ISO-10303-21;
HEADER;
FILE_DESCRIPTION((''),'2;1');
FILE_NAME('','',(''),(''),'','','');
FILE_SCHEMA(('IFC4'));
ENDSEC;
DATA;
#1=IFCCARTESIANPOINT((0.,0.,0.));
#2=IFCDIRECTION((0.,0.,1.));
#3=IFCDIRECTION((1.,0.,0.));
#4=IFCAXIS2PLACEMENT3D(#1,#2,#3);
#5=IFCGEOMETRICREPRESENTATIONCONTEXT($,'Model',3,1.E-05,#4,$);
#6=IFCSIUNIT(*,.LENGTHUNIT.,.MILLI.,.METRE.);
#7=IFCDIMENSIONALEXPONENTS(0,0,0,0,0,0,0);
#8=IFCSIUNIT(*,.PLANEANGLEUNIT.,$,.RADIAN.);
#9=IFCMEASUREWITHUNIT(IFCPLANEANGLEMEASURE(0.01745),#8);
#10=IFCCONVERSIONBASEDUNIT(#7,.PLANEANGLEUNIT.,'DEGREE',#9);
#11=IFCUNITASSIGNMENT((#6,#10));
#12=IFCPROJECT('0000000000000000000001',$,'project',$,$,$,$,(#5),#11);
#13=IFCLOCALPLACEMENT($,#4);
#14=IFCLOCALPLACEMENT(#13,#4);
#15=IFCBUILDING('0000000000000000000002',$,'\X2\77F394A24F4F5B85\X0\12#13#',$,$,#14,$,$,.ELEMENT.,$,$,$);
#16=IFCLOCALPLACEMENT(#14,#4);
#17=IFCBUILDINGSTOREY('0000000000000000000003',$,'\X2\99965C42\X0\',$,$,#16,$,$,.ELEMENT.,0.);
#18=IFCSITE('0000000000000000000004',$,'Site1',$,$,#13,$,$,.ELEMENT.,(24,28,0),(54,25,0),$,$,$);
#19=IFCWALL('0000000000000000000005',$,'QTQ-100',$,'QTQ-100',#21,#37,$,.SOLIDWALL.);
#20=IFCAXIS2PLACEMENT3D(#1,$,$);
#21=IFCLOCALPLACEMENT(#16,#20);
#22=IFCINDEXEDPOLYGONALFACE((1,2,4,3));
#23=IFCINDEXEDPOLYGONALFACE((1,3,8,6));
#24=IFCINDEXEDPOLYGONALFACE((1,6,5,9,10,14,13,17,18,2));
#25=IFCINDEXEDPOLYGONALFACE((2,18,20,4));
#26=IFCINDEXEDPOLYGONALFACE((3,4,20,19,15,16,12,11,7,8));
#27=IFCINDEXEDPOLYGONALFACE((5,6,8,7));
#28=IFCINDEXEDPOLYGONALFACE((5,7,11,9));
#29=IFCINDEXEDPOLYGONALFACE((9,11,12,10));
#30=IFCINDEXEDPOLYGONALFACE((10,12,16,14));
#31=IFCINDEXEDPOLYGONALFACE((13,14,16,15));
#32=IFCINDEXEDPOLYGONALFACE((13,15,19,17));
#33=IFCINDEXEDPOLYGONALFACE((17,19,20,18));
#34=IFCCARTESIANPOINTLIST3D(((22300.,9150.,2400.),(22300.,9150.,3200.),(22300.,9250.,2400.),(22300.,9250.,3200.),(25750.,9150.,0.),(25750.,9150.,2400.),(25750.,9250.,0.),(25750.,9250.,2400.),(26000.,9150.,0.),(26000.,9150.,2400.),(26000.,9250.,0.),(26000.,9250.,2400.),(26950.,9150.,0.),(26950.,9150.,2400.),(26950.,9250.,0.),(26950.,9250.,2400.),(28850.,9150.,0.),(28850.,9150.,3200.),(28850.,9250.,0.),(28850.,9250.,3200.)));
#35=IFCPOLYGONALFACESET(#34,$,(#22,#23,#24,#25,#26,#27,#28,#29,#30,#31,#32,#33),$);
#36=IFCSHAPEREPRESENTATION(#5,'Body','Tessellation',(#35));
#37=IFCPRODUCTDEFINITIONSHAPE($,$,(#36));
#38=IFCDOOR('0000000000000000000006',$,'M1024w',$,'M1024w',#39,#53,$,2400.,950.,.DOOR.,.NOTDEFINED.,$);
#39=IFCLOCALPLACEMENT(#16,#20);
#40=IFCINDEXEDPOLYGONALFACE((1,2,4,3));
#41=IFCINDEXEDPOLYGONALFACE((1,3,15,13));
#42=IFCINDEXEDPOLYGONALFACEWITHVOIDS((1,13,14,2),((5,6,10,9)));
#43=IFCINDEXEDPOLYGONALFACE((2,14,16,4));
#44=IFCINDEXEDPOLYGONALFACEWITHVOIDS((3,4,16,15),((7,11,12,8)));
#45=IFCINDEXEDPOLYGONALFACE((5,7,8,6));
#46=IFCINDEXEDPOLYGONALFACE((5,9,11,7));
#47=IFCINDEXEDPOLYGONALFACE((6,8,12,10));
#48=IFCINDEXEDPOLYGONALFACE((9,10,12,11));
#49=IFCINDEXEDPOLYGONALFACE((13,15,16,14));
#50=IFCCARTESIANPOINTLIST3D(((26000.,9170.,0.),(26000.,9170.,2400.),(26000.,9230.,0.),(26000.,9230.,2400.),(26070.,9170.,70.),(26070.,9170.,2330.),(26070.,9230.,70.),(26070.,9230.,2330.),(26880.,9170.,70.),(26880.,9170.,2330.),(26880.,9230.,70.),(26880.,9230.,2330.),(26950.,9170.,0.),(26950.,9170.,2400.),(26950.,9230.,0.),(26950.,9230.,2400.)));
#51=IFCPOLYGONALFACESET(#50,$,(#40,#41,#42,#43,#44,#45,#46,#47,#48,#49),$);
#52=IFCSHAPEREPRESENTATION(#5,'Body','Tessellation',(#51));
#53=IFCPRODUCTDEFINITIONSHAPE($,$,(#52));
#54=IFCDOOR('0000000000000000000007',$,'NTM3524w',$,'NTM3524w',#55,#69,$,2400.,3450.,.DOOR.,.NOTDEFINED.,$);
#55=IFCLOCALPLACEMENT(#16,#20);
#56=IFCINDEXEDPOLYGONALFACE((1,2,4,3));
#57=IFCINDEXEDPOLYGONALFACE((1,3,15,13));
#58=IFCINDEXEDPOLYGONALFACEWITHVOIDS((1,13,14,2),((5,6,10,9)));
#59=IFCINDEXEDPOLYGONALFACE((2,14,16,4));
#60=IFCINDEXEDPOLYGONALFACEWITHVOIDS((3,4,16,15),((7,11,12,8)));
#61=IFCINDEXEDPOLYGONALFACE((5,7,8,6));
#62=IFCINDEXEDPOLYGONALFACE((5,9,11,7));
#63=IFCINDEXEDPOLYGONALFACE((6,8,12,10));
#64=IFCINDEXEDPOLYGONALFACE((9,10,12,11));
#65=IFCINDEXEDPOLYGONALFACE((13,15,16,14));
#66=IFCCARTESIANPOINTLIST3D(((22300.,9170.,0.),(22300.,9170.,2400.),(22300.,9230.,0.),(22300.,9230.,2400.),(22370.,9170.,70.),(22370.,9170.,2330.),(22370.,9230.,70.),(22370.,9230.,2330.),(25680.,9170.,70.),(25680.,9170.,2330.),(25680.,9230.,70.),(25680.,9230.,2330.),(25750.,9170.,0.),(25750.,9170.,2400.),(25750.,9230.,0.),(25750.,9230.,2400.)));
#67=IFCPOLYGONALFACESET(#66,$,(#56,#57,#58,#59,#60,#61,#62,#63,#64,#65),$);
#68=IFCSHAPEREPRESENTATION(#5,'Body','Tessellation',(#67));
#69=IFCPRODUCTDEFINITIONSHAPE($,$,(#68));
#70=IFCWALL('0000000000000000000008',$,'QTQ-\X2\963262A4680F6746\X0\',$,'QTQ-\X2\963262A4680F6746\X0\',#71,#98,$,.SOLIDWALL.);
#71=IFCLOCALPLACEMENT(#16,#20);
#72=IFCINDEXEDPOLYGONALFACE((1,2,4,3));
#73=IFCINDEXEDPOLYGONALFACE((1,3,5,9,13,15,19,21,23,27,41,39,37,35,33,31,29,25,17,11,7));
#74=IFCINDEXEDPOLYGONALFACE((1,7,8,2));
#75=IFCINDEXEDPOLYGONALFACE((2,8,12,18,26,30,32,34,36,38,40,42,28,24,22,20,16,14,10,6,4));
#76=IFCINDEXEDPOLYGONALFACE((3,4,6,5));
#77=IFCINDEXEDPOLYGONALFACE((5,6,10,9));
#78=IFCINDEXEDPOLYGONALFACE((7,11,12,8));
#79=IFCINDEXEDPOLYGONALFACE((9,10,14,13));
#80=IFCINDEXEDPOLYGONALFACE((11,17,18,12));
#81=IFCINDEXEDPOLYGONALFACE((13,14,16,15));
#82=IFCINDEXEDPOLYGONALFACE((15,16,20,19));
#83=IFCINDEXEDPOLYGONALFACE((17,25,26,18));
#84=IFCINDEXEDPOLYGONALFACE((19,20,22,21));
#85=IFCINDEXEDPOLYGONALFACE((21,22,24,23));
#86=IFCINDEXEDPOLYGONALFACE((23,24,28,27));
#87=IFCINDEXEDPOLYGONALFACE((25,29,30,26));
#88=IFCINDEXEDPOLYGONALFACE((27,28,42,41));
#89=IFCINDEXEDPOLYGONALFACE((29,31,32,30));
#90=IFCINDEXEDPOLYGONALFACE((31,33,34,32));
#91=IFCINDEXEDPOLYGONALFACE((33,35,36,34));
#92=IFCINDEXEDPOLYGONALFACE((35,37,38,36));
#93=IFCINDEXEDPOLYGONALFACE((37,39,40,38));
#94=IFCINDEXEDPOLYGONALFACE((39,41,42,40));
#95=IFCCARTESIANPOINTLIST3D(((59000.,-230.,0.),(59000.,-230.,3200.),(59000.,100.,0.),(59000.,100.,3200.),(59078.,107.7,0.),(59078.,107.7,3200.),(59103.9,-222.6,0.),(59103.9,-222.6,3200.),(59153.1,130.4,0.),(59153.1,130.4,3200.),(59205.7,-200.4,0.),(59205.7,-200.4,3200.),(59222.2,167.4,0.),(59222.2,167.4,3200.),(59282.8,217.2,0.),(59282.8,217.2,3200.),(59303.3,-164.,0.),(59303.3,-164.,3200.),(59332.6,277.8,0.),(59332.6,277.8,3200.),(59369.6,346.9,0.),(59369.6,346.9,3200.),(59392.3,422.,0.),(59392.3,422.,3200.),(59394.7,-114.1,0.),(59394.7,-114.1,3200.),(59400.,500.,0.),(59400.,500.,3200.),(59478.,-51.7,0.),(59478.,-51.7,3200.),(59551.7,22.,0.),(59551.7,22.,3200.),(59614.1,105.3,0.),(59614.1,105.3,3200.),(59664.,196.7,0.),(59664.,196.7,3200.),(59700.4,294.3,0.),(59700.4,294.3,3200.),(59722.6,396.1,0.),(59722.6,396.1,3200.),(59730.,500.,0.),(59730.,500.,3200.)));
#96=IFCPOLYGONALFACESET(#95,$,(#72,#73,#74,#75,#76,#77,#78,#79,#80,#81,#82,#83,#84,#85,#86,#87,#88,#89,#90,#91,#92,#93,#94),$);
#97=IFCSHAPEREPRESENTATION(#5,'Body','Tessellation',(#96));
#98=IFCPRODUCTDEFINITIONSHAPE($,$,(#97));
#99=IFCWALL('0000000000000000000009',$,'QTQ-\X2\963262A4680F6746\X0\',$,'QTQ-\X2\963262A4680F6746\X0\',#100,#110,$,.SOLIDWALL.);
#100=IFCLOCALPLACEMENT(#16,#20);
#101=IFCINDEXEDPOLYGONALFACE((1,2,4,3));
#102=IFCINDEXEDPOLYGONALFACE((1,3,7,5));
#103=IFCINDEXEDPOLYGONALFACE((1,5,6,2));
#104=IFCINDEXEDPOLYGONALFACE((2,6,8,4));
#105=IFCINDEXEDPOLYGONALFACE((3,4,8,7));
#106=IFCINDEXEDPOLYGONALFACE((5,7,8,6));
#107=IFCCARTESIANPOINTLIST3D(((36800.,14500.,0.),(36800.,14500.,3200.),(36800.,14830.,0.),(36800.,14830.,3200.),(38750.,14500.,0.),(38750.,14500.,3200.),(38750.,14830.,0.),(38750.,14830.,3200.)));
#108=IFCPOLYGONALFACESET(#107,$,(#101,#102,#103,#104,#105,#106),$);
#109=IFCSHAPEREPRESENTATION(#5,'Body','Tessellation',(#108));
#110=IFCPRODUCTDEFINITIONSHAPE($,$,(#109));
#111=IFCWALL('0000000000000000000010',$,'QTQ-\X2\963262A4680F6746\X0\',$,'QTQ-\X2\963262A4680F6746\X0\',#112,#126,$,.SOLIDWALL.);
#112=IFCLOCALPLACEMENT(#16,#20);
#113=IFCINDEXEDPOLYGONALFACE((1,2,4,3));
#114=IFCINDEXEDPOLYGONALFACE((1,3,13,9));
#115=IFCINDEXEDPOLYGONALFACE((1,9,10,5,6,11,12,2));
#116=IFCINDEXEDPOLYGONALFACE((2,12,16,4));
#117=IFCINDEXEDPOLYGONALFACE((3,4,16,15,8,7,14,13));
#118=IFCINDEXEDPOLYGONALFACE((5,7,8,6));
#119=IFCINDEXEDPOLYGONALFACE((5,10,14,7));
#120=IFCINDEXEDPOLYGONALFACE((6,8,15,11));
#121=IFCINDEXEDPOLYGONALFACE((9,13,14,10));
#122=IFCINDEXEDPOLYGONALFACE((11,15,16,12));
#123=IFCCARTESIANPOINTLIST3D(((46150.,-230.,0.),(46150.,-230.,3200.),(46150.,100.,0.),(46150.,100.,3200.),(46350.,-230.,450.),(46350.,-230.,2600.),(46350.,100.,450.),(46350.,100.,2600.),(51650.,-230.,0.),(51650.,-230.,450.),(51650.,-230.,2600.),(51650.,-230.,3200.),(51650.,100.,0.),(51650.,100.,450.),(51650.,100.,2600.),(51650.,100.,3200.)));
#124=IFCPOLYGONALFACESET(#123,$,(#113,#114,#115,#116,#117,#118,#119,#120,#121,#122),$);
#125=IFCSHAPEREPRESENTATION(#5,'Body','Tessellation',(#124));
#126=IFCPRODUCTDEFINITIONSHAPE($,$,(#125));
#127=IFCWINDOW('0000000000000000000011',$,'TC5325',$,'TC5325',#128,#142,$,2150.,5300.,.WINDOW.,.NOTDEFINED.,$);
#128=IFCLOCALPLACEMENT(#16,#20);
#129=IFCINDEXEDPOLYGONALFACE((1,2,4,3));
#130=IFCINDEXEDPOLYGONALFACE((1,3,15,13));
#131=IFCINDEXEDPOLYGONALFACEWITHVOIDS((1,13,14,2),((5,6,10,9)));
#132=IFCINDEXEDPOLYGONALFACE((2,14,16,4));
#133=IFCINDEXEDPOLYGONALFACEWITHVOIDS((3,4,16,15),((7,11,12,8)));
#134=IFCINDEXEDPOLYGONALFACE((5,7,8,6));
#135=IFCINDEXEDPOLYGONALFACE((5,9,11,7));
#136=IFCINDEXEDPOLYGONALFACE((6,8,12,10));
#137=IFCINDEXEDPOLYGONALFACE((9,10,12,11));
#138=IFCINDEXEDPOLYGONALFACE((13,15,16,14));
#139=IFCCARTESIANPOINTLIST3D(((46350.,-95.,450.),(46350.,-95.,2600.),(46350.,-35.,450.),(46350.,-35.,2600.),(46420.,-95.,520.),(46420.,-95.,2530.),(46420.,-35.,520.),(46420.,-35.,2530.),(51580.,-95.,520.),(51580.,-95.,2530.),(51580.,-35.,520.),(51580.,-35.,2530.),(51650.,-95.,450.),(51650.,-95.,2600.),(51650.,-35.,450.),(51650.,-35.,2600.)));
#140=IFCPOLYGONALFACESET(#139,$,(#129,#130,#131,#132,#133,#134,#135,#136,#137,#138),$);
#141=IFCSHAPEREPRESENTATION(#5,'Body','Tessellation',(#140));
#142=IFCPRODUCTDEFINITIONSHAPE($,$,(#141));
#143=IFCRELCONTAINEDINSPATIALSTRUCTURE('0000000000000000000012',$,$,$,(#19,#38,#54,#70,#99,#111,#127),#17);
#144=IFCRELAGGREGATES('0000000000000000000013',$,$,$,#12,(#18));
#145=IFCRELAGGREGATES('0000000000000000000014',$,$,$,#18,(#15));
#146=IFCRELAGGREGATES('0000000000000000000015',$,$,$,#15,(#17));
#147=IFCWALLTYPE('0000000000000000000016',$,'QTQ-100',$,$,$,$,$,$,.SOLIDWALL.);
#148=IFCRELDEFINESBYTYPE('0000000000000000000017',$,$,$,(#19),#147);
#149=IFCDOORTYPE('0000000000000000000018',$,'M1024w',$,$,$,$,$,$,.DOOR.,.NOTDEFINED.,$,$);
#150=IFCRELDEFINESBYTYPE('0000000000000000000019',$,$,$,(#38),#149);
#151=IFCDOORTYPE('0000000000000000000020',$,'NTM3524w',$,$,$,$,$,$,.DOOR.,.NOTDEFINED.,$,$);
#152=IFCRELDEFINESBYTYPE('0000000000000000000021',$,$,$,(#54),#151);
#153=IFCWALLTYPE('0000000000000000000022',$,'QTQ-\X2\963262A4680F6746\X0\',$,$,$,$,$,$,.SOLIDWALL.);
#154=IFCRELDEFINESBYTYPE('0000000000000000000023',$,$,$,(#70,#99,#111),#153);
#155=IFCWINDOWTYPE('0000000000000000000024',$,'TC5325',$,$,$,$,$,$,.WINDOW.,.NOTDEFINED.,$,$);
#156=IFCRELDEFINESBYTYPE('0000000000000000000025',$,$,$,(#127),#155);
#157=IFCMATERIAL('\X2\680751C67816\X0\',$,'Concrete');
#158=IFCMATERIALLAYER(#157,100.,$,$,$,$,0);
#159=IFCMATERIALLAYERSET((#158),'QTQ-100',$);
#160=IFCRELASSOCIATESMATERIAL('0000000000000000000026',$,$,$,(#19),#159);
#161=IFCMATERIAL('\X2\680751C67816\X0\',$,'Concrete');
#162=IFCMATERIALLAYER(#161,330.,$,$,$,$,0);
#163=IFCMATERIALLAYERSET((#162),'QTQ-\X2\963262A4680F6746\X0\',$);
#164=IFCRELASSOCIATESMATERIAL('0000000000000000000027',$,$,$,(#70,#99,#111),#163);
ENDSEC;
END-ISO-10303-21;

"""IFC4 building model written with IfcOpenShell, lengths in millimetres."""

from ifc_helpers import new_model, entity, si_unit, converted_unit, point, frame, frame_2d, origin_with_axes, place, context, project, spatial, polyline, circle_curve, trimmed, segment, composite_curve, outline, extrude, material, layer, layer_set, type_object, element, fill, save


model = new_model("IFC4")

# Units and contexts
model_context = context("Model", 3, precision=1e-05, world=origin_with_axes())
ifc_project = project(units=[si_unit("LENGTHUNIT", "METRE", prefix="MILLI"), converted_unit("PLANEANGLEUNIT", "DEGREE", entity("IfcPlaneAngleMeasure", 0.01745), si_unit("PLANEANGLEUNIT", "RADIAN"), dimensions=[0, 0, 0, 0, 0, 0, 0])], contexts=[model_context])

# Site, building, storey
site_placement = place(None, origin_with_axes())
site = spatial("IfcSite", under=ifc_project, at=site_placement, Name="Site1", CompositionType="ELEMENT", RefLatitude=(24, 28, 0), RefLongitude=(54, 25, 0))
building_placement = place(site_placement, origin_with_axes())
building = spatial("IfcBuilding", under=site, at=building_placement, Name="石钢住宅12#13#", CompositionType="ELEMENT")
storey_placement = place(building_placement, origin_with_axes())
storey = spatial("IfcBuildingStorey", under=building, at=storey_placement, Name="首层", CompositionType="ELEMENT", Elevation=0.0)

# Shared definitions
ifc_material_1 = material(Name="标准砖", Category="Concrete")
ifc_layer_1 = layer(ifc_material_1, 100.0, Priority=0)
ifc_layer_set_1 = layer_set([ifc_layer_1], Name="QTQ-100")
wall_type_1 = type_object("IfcWallType", Name="QTQ-100", PredefinedType="SOLIDWALL")

# Wall, openings, doors
wall_1_placement = place(storey_placement, origin_with_axes())
wall_1 = element("IfcWall", 1, at=wall_1_placement, inside=storey, type_object=wall_type_1, material=ifc_layer_set_1, Name="QTQ-100", ObjectType="QTQ-100", PredefinedType="SOLIDWALL", context=model_context, shape_type="SweptSolid", body=[
    extrude(outline(polyline([(0.0, 0.0), (3200.0, 0.0), (3200.0, 6550.0), (0.0, 6550.0), (0.0, 0.0)])), frame((22300.0, 9250.0, 3200.0), z_axis=(0.0, -1.0, 0.0), x_axis=(0.0, 0.0, -1.0)), (0.0, 0.0, 1.0), 100.0),
])
opening_1_placement = place(storey_placement, origin_with_axes())
opening_1 = element("IfcOpeningElement", 2, at=opening_1_placement, cuts=wall_1, PredefinedType="OPENING", context=model_context, shape_type="SweptSolid", body=[
    extrude(outline(polyline([(0.0, 0.0), (950.0, 0.0), (950.0, 2400.0), (0.0, 2400.0), (0.0, 0.0)])), frame((26000.0, 10250.0, 0.0), z_axis=(0.0, -1.0, 0.0), x_axis=(1.0, 0.0, 0.0)), (0.0, 0.0, 1.0), 2100.0),
])
opening_2_placement = place(storey_placement, origin_with_axes())
opening_2 = element("IfcOpeningElement", 3, at=opening_2_placement, cuts=wall_1, PredefinedType="OPENING", context=model_context, shape_type="SweptSolid", body=[
    extrude(outline(polyline([(0.0, 0.0), (3450.0, 0.0), (3450.0, 2400.0), (0.0, 2400.0), (0.0, 0.0)])), frame((22300.0, 10250.0, 0.0), z_axis=(0.0, -1.0, 0.0), x_axis=(1.0, 0.0, 0.0)), (0.0, 0.0, 1.0), 2100.0),
])
door_type_1 = type_object("IfcDoorType", Name="M1024w", OperationType="NOTDEFINED", PredefinedType="DOOR")
door_1_placement = place(storey_placement, origin_with_axes())
door_1 = element("IfcDoor", 4, at=door_1_placement, inside=storey, type_object=door_type_1, Name="M1024w", ObjectType="M1024w", OperationType="NOTDEFINED", OverallHeight=2400.0, OverallWidth=950.0, PredefinedType="DOOR", context=model_context, shape_type="SweptSolid", body=[
    extrude(outline(polyline([(-475.0, -1200.0), (475.0, -1200.0), (475.0, 1200.0), (-475.0, 1200.0), (-475.0, -1200.0)]), holes=[polyline([(-405.0, -1130.0), (-405.0, 1130.0), (405.0, 1130.0), (405.0, -1130.0), (-405.0, -1130.0)])]), frame((26475.0, 9230.0, 1200.0), z_axis=(0.0, -1.0, 0.0), x_axis=(1.0, 0.0, 0.0)), (0.0, 0.0, 1.0), 60.0),
])
fill(opening_1, door_1)
door_type_2 = type_object("IfcDoorType", Name="NTM3524w", OperationType="NOTDEFINED", PredefinedType="DOOR")
door_2_placement = place(storey_placement, origin_with_axes())
door_2 = element("IfcDoor", 5, at=door_2_placement, inside=storey, type_object=door_type_2, Name="NTM3524w", ObjectType="NTM3524w", OperationType="NOTDEFINED", OverallHeight=2400.0, OverallWidth=3450.0, PredefinedType="DOOR", context=model_context, shape_type="SweptSolid", body=[
    extrude(outline(polyline([(-1725.0, -1200.0), (1725.0, -1200.0), (1725.0, 1200.0), (-1725.0, 1200.0), (-1725.0, -1200.0)]), holes=[polyline([(-1655.0, -1130.0), (-1655.0, 1130.0), (1655.0, 1130.0), (1655.0, -1130.0), (-1655.0, -1130.0)])]), frame((24025.0, 9230.0, 1200.0), z_axis=(0.0, -1.0, 0.0), x_axis=(1.0, 0.0, 0.0)), (0.0, 0.0, 1.0), 60.0),
])
fill(opening_2, door_2)

# Walls
ifc_material_2 = material(Name="标准砖", Category="Concrete")
ifc_layer_2 = layer(ifc_material_2, 330.0, Priority=0)
ifc_layer_set_2 = layer_set([ifc_layer_2], Name="QTQ-防护栏杆")
wall_type_2 = type_object("IfcWallType", Name="QTQ-防护栏杆", PredefinedType="SOLIDWALL")
wall_2_placement = place(storey_placement, origin_with_axes())
element("IfcWall", 6, at=wall_2_placement, inside=storey, type_object=wall_type_2, material=ifc_layer_set_2, Name="QTQ-防护栏杆", ObjectType="QTQ-防护栏杆", PredefinedType="SOLIDWALL", context=model_context, shape_type="SweptSolid", body=[
    extrude(outline(composite_curve([segment(polyline([(-230.0, -500.0), (100.0, -500.0)]), True, "CONTINUOUS"), segment(trimmed(circle_curve(frame_2d((500.0, -500.0), x_axis=(1.0, 0.0)), 400.0), [point((100.0, -500.0))], [point((500.0, -100.0))], False, "CARTESIAN"), True, "CONTINUOUS"), segment(polyline([(500.0, -100.0), (500.0, 230.0)]), True, "CONTINUOUS"), segment(trimmed(circle_curve(frame_2d((500.0, -500.0), x_axis=(1.0, 0.0)), 730.0), [point((500.0, 230.0))], [point((-230.0, -500.0))], True, "CARTESIAN"), True, "CONTINUOUS")], self_intersect=False)), frame((59500.0, 0.0, 0.0), z_axis=(0.0, 0.0, 1.0), x_axis=(-1.0, 0.0, 0.0)), (0.0, 0.0, 1.0), 3200.0),
])
wall_3_placement = place(storey_placement, origin_with_axes())
element("IfcWall", 7, at=wall_3_placement, inside=storey, type_object=wall_type_2, material=ifc_layer_set_2, Name="QTQ-防护栏杆", ObjectType="QTQ-防护栏杆", PredefinedType="SOLIDWALL", context=model_context, shape_type="SweptSolid", body=[
    extrude(outline(polyline([(0.0, 0.0), (3200.0, 0.0), (3200.0, 1950.0), (0.0, 1950.0), (0.0, 0.0)])), frame((38750.0, 14500.0, 3200.0), z_axis=(0.0, 1.0, 0.0), x_axis=(0.0, 0.0, -1.0)), (0.0, 0.0, 1.0), 330.0),
])

# Wall, opening, window
wall_4_placement = place(storey_placement, origin_with_axes())
wall_4 = element("IfcWall", 8, at=wall_4_placement, inside=storey, type_object=wall_type_2, material=ifc_layer_set_2, Name="QTQ-防护栏杆", ObjectType="QTQ-防护栏杆", PredefinedType="SOLIDWALL", context=model_context, shape_type="SweptSolid", body=[
    extrude(outline(polyline([(0.0, 0.0), (3200.0, 0.0), (3200.0, 5500.0), (0.0, 5500.0), (0.0, 0.0)])), frame((51650.0, -230.0, 3200.0), z_axis=(0.0, 1.0, 0.0), x_axis=(0.0, 0.0, -1.0)), (0.0, 0.0, 1.0), 330.0),
])
opening_3_placement = place(storey_placement, origin_with_axes())
opening_3 = element("IfcOpeningElement", 9, at=opening_3_placement, cuts=wall_4, PredefinedType="OPENING", context=model_context, shape_type="SweptSolid", body=[
    extrude(outline(polyline([(0.0, 0.0), (5300.0, 0.0), (5300.0, 2150.0), (0.0, 2150.0), (0.0, 0.0)])), frame((51650.0, -1230.0, 450.0), z_axis=(0.0, 1.0, 0.0), x_axis=(-1.0, 0.0, 0.0)), (0.0, 0.0, 1.0), 2330.0),
])
window_type_1 = type_object("IfcWindowType", Name="TC5325", PartitioningType="NOTDEFINED", PredefinedType="WINDOW")
window_1_placement = place(storey_placement, origin_with_axes())
window_1 = element("IfcWindow", 10, at=window_1_placement, inside=storey, type_object=window_type_1, Name="TC5325", ObjectType="TC5325", OverallHeight=2150.0, OverallWidth=5300.0, PartitioningType="NOTDEFINED", PredefinedType="WINDOW", context=model_context, shape_type="SweptSolid", body=[
    extrude(outline(polyline([(-2650.0, -1075.0), (2650.0, -1075.0), (2650.0, 1075.0), (-2650.0, 1075.0), (-2650.0, -1075.0)]), holes=[polyline([(-2580.0, -1005.0), (-2580.0, 1005.0), (2580.0, 1005.0), (2580.0, -1005.0), (-2580.0, -1005.0)])]), frame((49000.0, -95.0, 1525.0), z_axis=(0.0, 1.0, 0.0), x_axis=(-1.0, 0.0, 0.0)), (0.0, 0.0, 1.0), 60.0),
])
fill(opening_3, window_1)

save(model, "model.ifc")
